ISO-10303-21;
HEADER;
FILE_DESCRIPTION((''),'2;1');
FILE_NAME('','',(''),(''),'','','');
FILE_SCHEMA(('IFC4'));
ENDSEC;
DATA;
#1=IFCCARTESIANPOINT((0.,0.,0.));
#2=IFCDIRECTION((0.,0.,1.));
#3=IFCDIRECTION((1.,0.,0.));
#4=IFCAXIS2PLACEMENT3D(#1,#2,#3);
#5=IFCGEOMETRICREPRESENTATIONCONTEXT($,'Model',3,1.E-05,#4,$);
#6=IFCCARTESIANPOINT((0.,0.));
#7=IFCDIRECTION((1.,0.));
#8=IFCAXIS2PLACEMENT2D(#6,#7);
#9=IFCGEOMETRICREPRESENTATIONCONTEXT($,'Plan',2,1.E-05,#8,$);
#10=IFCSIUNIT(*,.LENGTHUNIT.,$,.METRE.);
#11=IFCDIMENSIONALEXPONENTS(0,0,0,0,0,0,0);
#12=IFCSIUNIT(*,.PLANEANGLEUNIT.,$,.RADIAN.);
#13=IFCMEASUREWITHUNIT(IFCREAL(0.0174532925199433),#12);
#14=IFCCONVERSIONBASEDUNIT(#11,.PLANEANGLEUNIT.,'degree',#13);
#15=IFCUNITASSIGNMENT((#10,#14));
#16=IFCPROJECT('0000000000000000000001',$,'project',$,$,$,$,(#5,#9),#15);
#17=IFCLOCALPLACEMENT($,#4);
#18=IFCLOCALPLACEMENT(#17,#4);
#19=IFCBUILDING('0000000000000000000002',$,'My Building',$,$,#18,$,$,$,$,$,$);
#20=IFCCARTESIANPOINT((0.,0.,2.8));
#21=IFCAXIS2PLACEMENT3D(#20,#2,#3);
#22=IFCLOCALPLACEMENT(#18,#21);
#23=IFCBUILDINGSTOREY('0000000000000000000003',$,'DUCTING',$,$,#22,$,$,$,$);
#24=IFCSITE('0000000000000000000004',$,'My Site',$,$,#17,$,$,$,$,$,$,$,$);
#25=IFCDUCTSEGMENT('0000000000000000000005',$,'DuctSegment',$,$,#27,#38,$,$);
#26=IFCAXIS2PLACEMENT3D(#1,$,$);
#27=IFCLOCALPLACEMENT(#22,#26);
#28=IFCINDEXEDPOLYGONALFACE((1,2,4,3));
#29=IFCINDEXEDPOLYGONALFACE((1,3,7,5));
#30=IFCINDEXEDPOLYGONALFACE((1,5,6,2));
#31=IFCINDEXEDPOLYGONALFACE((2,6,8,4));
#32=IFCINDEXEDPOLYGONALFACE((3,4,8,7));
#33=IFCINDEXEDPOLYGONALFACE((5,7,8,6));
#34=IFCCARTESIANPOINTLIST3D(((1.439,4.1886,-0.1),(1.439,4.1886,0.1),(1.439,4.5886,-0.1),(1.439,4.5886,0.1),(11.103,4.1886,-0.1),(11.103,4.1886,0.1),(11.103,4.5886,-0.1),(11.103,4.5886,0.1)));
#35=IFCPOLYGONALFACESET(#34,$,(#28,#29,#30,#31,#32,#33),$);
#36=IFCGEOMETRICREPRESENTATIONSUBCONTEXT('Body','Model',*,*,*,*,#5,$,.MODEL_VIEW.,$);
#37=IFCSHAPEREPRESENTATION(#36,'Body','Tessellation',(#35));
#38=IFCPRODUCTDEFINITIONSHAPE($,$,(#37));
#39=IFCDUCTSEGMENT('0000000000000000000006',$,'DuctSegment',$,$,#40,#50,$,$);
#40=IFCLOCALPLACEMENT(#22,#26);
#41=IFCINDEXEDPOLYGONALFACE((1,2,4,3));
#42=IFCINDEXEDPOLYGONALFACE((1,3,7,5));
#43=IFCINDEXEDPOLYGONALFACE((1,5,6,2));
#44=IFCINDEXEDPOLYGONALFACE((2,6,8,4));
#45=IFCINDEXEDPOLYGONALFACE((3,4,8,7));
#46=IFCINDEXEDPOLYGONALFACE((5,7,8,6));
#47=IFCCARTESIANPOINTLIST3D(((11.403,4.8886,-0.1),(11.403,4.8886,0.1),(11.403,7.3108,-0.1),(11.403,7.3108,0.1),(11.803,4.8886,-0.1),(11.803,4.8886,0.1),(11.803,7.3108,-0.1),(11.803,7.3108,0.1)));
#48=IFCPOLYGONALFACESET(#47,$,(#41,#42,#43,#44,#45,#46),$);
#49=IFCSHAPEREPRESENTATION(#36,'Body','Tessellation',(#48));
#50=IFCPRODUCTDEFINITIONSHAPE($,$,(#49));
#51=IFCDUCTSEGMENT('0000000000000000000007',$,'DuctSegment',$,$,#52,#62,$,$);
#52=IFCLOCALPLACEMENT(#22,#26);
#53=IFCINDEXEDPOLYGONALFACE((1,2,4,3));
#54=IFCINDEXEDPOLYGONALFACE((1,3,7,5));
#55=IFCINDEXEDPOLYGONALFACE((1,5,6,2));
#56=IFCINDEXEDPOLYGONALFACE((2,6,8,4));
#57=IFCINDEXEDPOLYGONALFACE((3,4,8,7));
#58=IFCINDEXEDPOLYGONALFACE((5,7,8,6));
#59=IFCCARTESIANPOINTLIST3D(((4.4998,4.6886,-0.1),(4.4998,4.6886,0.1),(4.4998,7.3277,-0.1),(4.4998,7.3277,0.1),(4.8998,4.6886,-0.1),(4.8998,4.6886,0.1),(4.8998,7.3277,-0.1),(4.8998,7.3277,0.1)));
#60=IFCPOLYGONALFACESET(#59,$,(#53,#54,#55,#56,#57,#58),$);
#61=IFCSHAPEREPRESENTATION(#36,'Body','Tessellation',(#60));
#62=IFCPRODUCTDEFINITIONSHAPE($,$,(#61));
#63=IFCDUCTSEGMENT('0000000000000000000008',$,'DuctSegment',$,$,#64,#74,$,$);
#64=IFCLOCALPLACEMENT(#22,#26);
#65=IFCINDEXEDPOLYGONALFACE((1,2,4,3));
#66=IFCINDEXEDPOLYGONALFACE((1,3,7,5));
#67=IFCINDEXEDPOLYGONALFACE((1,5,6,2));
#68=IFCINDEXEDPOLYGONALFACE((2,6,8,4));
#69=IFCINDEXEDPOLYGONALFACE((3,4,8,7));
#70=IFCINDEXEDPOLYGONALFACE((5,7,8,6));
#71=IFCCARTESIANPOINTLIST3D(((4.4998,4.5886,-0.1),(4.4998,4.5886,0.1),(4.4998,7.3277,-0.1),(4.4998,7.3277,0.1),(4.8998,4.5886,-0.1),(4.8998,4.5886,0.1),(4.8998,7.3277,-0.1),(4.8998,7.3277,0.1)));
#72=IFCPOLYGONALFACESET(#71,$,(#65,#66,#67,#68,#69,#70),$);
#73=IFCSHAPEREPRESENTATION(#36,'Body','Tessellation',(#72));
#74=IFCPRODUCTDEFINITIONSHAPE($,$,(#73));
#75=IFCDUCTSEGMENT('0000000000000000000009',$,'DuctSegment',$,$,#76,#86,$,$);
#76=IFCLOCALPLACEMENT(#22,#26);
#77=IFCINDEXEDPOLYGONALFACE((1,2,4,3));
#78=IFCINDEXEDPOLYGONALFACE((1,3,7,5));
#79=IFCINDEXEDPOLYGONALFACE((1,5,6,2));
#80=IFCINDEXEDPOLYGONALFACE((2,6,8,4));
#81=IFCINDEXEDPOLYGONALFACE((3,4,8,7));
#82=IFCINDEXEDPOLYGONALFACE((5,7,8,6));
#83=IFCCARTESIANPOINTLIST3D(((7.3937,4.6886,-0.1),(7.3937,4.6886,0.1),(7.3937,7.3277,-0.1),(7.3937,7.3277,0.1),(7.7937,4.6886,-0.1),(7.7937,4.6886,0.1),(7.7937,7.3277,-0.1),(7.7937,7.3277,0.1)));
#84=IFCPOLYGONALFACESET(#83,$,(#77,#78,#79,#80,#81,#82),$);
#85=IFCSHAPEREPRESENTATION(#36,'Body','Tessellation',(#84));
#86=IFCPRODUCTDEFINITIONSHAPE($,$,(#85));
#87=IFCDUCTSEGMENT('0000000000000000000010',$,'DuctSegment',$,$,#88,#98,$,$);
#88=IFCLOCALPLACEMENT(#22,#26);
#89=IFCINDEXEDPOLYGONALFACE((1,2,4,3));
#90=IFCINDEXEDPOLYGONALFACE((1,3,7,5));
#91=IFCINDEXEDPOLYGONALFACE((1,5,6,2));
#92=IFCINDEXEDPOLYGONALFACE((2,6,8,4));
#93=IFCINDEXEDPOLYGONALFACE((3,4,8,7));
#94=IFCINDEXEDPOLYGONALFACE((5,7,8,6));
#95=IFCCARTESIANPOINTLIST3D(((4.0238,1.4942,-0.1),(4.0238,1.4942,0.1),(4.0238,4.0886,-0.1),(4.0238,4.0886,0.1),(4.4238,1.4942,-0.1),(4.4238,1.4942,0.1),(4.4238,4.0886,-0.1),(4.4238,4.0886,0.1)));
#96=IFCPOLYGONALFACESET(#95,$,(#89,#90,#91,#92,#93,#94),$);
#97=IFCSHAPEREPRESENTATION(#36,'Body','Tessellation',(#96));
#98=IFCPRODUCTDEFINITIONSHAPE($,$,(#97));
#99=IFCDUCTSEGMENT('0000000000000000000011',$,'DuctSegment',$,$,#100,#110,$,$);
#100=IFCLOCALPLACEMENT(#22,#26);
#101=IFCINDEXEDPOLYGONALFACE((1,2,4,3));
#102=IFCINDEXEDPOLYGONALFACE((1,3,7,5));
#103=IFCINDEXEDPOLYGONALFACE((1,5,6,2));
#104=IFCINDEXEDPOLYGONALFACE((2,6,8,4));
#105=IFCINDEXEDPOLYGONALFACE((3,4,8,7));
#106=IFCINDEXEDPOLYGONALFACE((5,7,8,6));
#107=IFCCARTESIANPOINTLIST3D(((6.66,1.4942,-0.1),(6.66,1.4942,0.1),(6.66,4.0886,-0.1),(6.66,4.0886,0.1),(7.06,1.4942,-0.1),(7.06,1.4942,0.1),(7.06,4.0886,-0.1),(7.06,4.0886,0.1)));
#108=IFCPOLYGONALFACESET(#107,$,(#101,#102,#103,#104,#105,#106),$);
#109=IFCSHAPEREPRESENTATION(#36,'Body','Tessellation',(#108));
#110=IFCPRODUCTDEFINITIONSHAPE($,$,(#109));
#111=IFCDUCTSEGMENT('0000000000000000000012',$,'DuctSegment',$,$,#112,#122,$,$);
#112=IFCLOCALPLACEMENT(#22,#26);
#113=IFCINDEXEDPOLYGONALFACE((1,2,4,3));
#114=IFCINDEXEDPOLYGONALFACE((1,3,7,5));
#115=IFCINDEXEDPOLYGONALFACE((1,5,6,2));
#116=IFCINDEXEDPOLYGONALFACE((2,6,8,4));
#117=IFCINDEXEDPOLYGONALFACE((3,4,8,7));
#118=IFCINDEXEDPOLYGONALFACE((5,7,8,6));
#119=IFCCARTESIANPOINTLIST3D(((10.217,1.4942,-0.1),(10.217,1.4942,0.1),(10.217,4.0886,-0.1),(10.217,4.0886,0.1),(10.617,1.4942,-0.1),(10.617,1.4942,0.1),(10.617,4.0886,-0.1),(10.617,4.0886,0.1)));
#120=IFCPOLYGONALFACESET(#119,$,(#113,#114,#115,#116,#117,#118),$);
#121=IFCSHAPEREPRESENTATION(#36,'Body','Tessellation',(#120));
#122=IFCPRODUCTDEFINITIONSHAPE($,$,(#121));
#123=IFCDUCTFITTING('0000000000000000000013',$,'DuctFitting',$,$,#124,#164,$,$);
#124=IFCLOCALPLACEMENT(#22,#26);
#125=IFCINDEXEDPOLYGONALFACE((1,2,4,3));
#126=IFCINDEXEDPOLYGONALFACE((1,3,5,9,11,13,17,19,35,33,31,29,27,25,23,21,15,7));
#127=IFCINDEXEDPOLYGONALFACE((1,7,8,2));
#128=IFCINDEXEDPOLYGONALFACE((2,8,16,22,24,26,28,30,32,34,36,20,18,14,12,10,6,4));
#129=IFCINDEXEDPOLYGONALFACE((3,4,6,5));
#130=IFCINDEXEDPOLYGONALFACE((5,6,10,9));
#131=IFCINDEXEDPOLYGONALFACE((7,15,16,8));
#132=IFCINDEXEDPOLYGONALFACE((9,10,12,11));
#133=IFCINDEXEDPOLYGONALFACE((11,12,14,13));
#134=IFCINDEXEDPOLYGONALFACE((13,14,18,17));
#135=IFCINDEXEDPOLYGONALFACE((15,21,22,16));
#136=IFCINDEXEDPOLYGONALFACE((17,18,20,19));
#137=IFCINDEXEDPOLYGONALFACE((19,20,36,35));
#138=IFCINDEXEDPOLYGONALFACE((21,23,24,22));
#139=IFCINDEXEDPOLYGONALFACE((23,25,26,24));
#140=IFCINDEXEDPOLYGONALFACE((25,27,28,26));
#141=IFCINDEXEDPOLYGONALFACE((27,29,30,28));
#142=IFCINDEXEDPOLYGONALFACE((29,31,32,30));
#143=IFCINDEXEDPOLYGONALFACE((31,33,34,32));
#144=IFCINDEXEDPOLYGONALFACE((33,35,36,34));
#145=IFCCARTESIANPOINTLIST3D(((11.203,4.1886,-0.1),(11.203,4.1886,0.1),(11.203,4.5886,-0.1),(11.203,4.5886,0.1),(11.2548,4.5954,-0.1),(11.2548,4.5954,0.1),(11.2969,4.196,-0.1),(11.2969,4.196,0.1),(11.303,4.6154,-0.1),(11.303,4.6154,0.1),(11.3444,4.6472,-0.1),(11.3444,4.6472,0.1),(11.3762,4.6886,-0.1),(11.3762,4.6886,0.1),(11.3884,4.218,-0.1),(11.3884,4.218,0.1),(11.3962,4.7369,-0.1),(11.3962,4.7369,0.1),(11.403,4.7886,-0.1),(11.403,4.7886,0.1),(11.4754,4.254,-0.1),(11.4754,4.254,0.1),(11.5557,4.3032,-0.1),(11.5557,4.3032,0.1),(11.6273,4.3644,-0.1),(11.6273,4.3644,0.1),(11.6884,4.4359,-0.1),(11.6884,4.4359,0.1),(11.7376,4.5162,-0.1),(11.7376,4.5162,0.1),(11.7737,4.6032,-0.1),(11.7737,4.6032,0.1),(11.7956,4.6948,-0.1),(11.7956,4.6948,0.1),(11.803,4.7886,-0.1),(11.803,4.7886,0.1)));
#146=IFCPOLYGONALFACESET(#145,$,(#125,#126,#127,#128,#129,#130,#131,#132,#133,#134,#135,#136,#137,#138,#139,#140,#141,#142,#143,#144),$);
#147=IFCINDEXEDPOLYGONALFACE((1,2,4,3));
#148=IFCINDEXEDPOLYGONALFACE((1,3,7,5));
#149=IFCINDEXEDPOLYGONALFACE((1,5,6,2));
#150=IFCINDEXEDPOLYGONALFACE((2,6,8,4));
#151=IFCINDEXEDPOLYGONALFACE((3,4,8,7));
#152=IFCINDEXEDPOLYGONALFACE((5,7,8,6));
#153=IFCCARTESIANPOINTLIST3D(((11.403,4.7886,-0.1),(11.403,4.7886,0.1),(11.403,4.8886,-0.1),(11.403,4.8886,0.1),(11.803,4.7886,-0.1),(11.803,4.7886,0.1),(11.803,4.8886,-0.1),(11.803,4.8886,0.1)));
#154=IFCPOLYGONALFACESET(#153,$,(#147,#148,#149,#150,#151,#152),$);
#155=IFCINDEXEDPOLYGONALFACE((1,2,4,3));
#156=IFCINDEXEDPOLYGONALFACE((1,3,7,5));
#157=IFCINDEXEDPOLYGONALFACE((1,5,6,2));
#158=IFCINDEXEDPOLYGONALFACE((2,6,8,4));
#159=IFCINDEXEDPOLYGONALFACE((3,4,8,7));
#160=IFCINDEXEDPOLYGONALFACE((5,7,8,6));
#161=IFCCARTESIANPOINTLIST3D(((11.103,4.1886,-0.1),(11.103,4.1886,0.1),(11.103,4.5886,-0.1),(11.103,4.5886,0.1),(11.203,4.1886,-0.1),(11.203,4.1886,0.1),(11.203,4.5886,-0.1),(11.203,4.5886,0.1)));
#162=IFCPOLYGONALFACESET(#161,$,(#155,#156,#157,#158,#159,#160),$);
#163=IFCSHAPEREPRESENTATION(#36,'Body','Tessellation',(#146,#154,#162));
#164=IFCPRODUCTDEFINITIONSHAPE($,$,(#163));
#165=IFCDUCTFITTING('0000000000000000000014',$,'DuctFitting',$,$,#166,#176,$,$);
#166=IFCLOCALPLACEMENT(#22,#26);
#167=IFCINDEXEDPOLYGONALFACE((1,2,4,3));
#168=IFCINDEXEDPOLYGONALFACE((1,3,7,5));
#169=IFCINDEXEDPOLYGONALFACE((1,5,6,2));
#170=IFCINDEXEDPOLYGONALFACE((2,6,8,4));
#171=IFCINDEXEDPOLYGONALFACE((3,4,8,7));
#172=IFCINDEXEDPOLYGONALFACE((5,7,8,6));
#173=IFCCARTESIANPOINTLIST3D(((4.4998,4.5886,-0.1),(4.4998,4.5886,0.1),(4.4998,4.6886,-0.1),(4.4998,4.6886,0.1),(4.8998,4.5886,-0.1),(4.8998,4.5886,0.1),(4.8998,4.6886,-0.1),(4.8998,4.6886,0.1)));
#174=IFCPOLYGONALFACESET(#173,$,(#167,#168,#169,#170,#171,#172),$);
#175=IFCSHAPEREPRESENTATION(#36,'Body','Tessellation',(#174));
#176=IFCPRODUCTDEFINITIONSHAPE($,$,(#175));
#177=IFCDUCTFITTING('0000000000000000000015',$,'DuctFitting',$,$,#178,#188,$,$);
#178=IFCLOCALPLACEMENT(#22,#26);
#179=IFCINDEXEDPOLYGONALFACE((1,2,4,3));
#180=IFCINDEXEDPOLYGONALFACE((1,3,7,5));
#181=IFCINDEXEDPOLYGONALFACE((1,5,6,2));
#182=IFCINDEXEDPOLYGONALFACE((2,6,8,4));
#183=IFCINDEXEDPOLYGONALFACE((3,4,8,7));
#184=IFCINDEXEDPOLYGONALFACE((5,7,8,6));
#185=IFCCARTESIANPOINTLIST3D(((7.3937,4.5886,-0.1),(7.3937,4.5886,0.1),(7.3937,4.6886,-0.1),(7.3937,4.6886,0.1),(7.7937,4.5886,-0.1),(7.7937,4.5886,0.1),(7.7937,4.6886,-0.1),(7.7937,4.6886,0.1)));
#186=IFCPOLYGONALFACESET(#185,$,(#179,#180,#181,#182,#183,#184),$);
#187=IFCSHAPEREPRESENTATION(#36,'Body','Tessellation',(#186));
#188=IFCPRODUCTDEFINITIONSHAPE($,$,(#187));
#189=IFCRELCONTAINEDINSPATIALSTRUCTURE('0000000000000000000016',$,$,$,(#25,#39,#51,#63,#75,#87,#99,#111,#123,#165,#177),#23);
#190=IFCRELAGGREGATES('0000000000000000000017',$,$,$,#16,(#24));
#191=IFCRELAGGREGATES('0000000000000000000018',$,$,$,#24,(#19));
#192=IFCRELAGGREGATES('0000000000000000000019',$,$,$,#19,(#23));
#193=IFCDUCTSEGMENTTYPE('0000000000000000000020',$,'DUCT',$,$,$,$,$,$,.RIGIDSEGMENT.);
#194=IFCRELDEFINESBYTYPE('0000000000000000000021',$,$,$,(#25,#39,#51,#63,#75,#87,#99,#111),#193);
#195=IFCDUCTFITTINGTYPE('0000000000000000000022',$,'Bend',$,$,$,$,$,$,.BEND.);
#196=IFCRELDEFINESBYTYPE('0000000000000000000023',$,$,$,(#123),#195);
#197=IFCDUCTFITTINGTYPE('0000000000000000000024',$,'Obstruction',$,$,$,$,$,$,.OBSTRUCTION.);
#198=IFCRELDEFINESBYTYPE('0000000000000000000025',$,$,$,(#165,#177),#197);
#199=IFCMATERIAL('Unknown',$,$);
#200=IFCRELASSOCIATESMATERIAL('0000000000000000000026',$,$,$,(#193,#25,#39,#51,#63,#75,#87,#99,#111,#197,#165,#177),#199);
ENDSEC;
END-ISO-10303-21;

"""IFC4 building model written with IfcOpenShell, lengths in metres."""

from ifc_helpers import new_model, entity, si_unit, converted_unit, frame, origin_with_axes, origin_2d_with_axis, place, context, subcontext, project, spatial, line, arc, indexed_curve, rectangle, outline, extrude, source, transform, mapped, material, material_profile, profile_set, profile_usage, type_object, type_shapes, element, save


model = new_model("IFC4")

# Units and contexts
model_context = context("Model", 3, precision=1e-05, world=origin_with_axes())
plan_context = context("Plan", 2, precision=1e-05, world=origin_2d_with_axis())
body_context = subcontext(model_context, "Body", "Model", "MODEL_VIEW")
ifc_project = project(units=[si_unit("LENGTHUNIT", "METRE"), converted_unit("PLANEANGLEUNIT", "degree", entity("IfcReal", 0.0174532925199433), si_unit("PLANEANGLEUNIT", "RADIAN"), dimensions=[0, 0, 0, 0, 0, 0, 0])], contexts=[model_context, plan_context])

# Site, building, storey
site_placement = place(None, origin_with_axes())
site = spatial("IfcSite", under=ifc_project, at=site_placement, Name="My Site")
building_placement = place(site_placement, origin_with_axes())
building = spatial("IfcBuilding", under=site, at=building_placement, Name="My Building")
storey_placement = place(building_placement, frame((0.0, 0.0, 2.8), z_axis=(0.0, 0.0, 1.0), x_axis=(1.0, 0.0, 0.0)))
storey = spatial("IfcBuildingStorey", under=building, at=storey_placement, Name="DUCTING")

# Duct segments
ifc_material = material(Name="Unknown")
ifc_material_profile_1 = material_profile(ifc_material, rectangle(XDim=0.4, YDim=0.2))
ifc_profile_set_1 = profile_set([ifc_material_profile_1])
ifc_profile_usage_1 = profile_usage(ifc_profile_set_1, cardinal=5)
duct_segment_type = type_object("IfcDuctSegmentType", Name="DUCT", PredefinedType="RIGIDSEGMENT", material=ifc_profile_set_1)
duct_segment_1_placement = place(storey_placement, frame((1.439, 4.3886, 0.0), z_axis=(1.0, 0.0, 0.0), x_axis=(0.0, 1.0, 0.0)))
element("IfcDuctSegment", 1, at=duct_segment_1_placement, inside=storey, type_object=duct_segment_type, material=ifc_profile_usage_1, Name="DuctSegment", context=body_context, shape_type="SweptSolid", body=[
    extrude(rectangle(XDim=0.4, YDim=0.2), origin_with_axes(), (0.0, 0.0, 1.0), 9.6641),
])
ifc_profile_usage_2 = profile_usage(ifc_profile_set_1, cardinal=5)
duct_segment_2_placement = place(storey_placement, frame((11.603, 4.8886, 0.0), z_axis=(0.0, 1.0, 0.0), x_axis=(-1.0, 0.0, 0.0)))
element("IfcDuctSegment", 2, at=duct_segment_2_placement, inside=storey, type_object=duct_segment_type, material=ifc_profile_usage_2, Name="DuctSegment", context=body_context, shape_type="SweptSolid", body=[
    extrude(rectangle(XDim=0.4, YDim=0.2), origin_with_axes(), (0.0, 0.0, 1.0), 2.4222),
])
ifc_profile_usage_3 = profile_usage(ifc_profile_set_1, cardinal=5)
duct_segment_3_placement = place(storey_placement, frame((4.6998, 4.6886, 0.0), z_axis=(0.0, 1.0, 0.0), x_axis=(-1.0, 0.0, 0.0)))
element("IfcDuctSegment", 3, at=duct_segment_3_placement, inside=storey, type_object=duct_segment_type, material=ifc_profile_usage_3, Name="DuctSegment", context=body_context, shape_type="SweptSolid", body=[
    extrude(rectangle(XDim=0.4, YDim=0.2), origin_with_axes(), (0.0, 0.0, 1.0), 2.6391),
])
ifc_profile_usage_4 = profile_usage(ifc_profile_set_1, cardinal=5)
duct_segment_4_placement = place(storey_placement, frame((4.6998, 4.5886, 0.0), z_axis=(0.0, 1.0, 0.0), x_axis=(-1.0, 0.0, 0.0)))
element("IfcDuctSegment", 4, at=duct_segment_4_placement, inside=storey, type_object=duct_segment_type, material=ifc_profile_usage_4, Name="DuctSegment", context=body_context, shape_type="SweptSolid", body=[
    extrude(rectangle(XDim=0.4, YDim=0.2), origin_with_axes(), (0.0, 0.0, 1.0), 2.7391),
])
ifc_profile_usage_5 = profile_usage(ifc_profile_set_1, cardinal=5)
duct_segment_5_placement = place(storey_placement, frame((7.5937, 4.6886, 0.0), z_axis=(0.0, 1.0, 0.0), x_axis=(-1.0, 0.0, 0.0)))
element("IfcDuctSegment", 5, at=duct_segment_5_placement, inside=storey, type_object=duct_segment_type, material=ifc_profile_usage_5, Name="DuctSegment", context=body_context, shape_type="SweptSolid", body=[
    extrude(rectangle(XDim=0.4, YDim=0.2), origin_with_axes(), (0.0, 0.0, 1.0), 2.6391),
])
ifc_profile_usage_6 = profile_usage(ifc_profile_set_1, cardinal=5)
duct_segment_6_placement = place(storey_placement, frame((4.2238, 4.0886, 0.0), z_axis=(0.0, -1.0, 0.0), x_axis=(-1.0, 0.0, 0.0)))
element("IfcDuctSegment", 6, at=duct_segment_6_placement, inside=storey, type_object=duct_segment_type, material=ifc_profile_usage_6, Name="DuctSegment", context=body_context, shape_type="SweptSolid", body=[
    extrude(rectangle(XDim=0.4, YDim=0.2), origin_with_axes(), (0.0, 0.0, 1.0), 2.5944),
])
ifc_profile_usage_7 = profile_usage(ifc_profile_set_1, cardinal=5)
duct_segment_7_placement = place(storey_placement, frame((6.86, 4.0886, 0.0), z_axis=(0.0, -1.0, 0.0), x_axis=(-1.0, 0.0, 0.0)))
element("IfcDuctSegment", 7, at=duct_segment_7_placement, inside=storey, type_object=duct_segment_type, material=ifc_profile_usage_7, Name="DuctSegment", context=body_context, shape_type="SweptSolid", body=[
    extrude(rectangle(XDim=0.4, YDim=0.2), origin_with_axes(), (0.0, 0.0, 1.0), 2.5944),
])
ifc_profile_usage_8 = profile_usage(ifc_profile_set_1, cardinal=5)
duct_segment_8_placement = place(storey_placement, frame((10.417, 4.0886, 0.0), z_axis=(0.0, -1.0, 0.0), x_axis=(-1.0, 0.0, 0.0)))
element("IfcDuctSegment", 8, at=duct_segment_8_placement, inside=storey, type_object=duct_segment_type, material=ifc_profile_usage_8, Name="DuctSegment", context=body_context, shape_type="SweptSolid", body=[
    extrude(rectangle(XDim=0.4, YDim=0.2), origin_with_axes(), (0.0, 0.0, 1.0), 2.5944),
])

# Duct fittings
duct_fitting_type_1 = type_object("IfcDuctFittingType", Name="Bend", PredefinedType="BEND")
shared_shape = source(origin_with_axes(), body_context, "Body", "SweptSolid", [
    extrude(outline(indexed_curve([(0.2, 0.0), (0.2586, -0.1414), (0.4, -0.2), (0.4, -0.6), (-0.0243, -0.4243), (-0.2, 0.0)], segments=[arc(1, 2, 3), line(3, 4), arc(4, 5, 6), line(6, 1)])), frame((0.0, -0.1, -0.1), z_axis=(0.0, -1.0, 0.0), x_axis=(1.0, 0.0, 0.0)), (0.0, 0.0, -1.0), 0.2),
    extrude(rectangle(XDim=0.4, YDim=0.2), origin_with_axes(), (0.0, 0.0, -1.0), 0.1),
    extrude(rectangle(XDim=0.4, YDim=0.2), frame((0.4, 0.0, -0.5), z_axis=(1.0, 0.0, 0.0), x_axis=(0.0, 0.0, 1.0)), (0.0, 0.0, 1.0), 0.1),
])
type_shapes(duct_fitting_type_1, [shared_shape])
duct_fitting_1_placement = place(storey_placement, frame((11.603, 4.8886, 0.0), z_axis=(0.0, 1.0, 0.0), x_axis=(-1.0, 0.0, 0.0)))
element("IfcDuctFitting", 9, at=duct_fitting_1_placement, inside=storey, type_object=duct_fitting_type_1, Name="DuctFitting", context=body_context, shape_type="MappedRepresentation", body=[
    mapped(shared_shape, transform((0.0, 0.0, 0.0), x_axis=(1.0, 0.0, 0.0), y_axis=(0.0, 1.0, 0.0), z_axis=(0.0, 0.0, 1.0), scale=1.0)),
])
ifc_material_profile_2 = material_profile(ifc_material, rectangle(XDim=0.4, YDim=0.2))
ifc_profile_set_2 = profile_set([ifc_material_profile_2])
ifc_profile_usage_9 = profile_usage(ifc_profile_set_2, cardinal=5)
duct_fitting_type_2 = type_object("IfcDuctFittingType", Name="Obstruction", PredefinedType="OBSTRUCTION", material=ifc_profile_set_2)
duct_fitting_2_placement = place(storey_placement, frame((4.6998, 4.5886, 0.0), z_axis=(0.0, 1.0, 0.0), x_axis=(-1.0, 0.0, 0.0)))
element("IfcDuctFitting", 10, at=duct_fitting_2_placement, inside=storey, type_object=duct_fitting_type_2, material=ifc_profile_usage_9, Name="DuctFitting", context=body_context, shape_type="SweptSolid", body=[
    extrude(rectangle(XDim=0.4, YDim=0.2), origin_with_axes(), (0.0, 0.0, 1.0), 0.1),
])
ifc_profile_usage_10 = profile_usage(ifc_profile_set_2, cardinal=5)
duct_fitting_3_placement = place(storey_placement, frame((7.5937, 4.5886, 0.0), z_axis=(0.0, 1.0, 0.0), x_axis=(-1.0, 0.0, 0.0)))
element("IfcDuctFitting", 11, at=duct_fitting_3_placement, inside=storey, type_object=duct_fitting_type_2, material=ifc_profile_usage_10, Name="DuctFitting", context=body_context, shape_type="SweptSolid", body=[
    extrude(rectangle(XDim=0.4, YDim=0.2), origin_with_axes(), (0.0, 0.0, 1.0), 0.1),
])

save(model, "model.ifc")
